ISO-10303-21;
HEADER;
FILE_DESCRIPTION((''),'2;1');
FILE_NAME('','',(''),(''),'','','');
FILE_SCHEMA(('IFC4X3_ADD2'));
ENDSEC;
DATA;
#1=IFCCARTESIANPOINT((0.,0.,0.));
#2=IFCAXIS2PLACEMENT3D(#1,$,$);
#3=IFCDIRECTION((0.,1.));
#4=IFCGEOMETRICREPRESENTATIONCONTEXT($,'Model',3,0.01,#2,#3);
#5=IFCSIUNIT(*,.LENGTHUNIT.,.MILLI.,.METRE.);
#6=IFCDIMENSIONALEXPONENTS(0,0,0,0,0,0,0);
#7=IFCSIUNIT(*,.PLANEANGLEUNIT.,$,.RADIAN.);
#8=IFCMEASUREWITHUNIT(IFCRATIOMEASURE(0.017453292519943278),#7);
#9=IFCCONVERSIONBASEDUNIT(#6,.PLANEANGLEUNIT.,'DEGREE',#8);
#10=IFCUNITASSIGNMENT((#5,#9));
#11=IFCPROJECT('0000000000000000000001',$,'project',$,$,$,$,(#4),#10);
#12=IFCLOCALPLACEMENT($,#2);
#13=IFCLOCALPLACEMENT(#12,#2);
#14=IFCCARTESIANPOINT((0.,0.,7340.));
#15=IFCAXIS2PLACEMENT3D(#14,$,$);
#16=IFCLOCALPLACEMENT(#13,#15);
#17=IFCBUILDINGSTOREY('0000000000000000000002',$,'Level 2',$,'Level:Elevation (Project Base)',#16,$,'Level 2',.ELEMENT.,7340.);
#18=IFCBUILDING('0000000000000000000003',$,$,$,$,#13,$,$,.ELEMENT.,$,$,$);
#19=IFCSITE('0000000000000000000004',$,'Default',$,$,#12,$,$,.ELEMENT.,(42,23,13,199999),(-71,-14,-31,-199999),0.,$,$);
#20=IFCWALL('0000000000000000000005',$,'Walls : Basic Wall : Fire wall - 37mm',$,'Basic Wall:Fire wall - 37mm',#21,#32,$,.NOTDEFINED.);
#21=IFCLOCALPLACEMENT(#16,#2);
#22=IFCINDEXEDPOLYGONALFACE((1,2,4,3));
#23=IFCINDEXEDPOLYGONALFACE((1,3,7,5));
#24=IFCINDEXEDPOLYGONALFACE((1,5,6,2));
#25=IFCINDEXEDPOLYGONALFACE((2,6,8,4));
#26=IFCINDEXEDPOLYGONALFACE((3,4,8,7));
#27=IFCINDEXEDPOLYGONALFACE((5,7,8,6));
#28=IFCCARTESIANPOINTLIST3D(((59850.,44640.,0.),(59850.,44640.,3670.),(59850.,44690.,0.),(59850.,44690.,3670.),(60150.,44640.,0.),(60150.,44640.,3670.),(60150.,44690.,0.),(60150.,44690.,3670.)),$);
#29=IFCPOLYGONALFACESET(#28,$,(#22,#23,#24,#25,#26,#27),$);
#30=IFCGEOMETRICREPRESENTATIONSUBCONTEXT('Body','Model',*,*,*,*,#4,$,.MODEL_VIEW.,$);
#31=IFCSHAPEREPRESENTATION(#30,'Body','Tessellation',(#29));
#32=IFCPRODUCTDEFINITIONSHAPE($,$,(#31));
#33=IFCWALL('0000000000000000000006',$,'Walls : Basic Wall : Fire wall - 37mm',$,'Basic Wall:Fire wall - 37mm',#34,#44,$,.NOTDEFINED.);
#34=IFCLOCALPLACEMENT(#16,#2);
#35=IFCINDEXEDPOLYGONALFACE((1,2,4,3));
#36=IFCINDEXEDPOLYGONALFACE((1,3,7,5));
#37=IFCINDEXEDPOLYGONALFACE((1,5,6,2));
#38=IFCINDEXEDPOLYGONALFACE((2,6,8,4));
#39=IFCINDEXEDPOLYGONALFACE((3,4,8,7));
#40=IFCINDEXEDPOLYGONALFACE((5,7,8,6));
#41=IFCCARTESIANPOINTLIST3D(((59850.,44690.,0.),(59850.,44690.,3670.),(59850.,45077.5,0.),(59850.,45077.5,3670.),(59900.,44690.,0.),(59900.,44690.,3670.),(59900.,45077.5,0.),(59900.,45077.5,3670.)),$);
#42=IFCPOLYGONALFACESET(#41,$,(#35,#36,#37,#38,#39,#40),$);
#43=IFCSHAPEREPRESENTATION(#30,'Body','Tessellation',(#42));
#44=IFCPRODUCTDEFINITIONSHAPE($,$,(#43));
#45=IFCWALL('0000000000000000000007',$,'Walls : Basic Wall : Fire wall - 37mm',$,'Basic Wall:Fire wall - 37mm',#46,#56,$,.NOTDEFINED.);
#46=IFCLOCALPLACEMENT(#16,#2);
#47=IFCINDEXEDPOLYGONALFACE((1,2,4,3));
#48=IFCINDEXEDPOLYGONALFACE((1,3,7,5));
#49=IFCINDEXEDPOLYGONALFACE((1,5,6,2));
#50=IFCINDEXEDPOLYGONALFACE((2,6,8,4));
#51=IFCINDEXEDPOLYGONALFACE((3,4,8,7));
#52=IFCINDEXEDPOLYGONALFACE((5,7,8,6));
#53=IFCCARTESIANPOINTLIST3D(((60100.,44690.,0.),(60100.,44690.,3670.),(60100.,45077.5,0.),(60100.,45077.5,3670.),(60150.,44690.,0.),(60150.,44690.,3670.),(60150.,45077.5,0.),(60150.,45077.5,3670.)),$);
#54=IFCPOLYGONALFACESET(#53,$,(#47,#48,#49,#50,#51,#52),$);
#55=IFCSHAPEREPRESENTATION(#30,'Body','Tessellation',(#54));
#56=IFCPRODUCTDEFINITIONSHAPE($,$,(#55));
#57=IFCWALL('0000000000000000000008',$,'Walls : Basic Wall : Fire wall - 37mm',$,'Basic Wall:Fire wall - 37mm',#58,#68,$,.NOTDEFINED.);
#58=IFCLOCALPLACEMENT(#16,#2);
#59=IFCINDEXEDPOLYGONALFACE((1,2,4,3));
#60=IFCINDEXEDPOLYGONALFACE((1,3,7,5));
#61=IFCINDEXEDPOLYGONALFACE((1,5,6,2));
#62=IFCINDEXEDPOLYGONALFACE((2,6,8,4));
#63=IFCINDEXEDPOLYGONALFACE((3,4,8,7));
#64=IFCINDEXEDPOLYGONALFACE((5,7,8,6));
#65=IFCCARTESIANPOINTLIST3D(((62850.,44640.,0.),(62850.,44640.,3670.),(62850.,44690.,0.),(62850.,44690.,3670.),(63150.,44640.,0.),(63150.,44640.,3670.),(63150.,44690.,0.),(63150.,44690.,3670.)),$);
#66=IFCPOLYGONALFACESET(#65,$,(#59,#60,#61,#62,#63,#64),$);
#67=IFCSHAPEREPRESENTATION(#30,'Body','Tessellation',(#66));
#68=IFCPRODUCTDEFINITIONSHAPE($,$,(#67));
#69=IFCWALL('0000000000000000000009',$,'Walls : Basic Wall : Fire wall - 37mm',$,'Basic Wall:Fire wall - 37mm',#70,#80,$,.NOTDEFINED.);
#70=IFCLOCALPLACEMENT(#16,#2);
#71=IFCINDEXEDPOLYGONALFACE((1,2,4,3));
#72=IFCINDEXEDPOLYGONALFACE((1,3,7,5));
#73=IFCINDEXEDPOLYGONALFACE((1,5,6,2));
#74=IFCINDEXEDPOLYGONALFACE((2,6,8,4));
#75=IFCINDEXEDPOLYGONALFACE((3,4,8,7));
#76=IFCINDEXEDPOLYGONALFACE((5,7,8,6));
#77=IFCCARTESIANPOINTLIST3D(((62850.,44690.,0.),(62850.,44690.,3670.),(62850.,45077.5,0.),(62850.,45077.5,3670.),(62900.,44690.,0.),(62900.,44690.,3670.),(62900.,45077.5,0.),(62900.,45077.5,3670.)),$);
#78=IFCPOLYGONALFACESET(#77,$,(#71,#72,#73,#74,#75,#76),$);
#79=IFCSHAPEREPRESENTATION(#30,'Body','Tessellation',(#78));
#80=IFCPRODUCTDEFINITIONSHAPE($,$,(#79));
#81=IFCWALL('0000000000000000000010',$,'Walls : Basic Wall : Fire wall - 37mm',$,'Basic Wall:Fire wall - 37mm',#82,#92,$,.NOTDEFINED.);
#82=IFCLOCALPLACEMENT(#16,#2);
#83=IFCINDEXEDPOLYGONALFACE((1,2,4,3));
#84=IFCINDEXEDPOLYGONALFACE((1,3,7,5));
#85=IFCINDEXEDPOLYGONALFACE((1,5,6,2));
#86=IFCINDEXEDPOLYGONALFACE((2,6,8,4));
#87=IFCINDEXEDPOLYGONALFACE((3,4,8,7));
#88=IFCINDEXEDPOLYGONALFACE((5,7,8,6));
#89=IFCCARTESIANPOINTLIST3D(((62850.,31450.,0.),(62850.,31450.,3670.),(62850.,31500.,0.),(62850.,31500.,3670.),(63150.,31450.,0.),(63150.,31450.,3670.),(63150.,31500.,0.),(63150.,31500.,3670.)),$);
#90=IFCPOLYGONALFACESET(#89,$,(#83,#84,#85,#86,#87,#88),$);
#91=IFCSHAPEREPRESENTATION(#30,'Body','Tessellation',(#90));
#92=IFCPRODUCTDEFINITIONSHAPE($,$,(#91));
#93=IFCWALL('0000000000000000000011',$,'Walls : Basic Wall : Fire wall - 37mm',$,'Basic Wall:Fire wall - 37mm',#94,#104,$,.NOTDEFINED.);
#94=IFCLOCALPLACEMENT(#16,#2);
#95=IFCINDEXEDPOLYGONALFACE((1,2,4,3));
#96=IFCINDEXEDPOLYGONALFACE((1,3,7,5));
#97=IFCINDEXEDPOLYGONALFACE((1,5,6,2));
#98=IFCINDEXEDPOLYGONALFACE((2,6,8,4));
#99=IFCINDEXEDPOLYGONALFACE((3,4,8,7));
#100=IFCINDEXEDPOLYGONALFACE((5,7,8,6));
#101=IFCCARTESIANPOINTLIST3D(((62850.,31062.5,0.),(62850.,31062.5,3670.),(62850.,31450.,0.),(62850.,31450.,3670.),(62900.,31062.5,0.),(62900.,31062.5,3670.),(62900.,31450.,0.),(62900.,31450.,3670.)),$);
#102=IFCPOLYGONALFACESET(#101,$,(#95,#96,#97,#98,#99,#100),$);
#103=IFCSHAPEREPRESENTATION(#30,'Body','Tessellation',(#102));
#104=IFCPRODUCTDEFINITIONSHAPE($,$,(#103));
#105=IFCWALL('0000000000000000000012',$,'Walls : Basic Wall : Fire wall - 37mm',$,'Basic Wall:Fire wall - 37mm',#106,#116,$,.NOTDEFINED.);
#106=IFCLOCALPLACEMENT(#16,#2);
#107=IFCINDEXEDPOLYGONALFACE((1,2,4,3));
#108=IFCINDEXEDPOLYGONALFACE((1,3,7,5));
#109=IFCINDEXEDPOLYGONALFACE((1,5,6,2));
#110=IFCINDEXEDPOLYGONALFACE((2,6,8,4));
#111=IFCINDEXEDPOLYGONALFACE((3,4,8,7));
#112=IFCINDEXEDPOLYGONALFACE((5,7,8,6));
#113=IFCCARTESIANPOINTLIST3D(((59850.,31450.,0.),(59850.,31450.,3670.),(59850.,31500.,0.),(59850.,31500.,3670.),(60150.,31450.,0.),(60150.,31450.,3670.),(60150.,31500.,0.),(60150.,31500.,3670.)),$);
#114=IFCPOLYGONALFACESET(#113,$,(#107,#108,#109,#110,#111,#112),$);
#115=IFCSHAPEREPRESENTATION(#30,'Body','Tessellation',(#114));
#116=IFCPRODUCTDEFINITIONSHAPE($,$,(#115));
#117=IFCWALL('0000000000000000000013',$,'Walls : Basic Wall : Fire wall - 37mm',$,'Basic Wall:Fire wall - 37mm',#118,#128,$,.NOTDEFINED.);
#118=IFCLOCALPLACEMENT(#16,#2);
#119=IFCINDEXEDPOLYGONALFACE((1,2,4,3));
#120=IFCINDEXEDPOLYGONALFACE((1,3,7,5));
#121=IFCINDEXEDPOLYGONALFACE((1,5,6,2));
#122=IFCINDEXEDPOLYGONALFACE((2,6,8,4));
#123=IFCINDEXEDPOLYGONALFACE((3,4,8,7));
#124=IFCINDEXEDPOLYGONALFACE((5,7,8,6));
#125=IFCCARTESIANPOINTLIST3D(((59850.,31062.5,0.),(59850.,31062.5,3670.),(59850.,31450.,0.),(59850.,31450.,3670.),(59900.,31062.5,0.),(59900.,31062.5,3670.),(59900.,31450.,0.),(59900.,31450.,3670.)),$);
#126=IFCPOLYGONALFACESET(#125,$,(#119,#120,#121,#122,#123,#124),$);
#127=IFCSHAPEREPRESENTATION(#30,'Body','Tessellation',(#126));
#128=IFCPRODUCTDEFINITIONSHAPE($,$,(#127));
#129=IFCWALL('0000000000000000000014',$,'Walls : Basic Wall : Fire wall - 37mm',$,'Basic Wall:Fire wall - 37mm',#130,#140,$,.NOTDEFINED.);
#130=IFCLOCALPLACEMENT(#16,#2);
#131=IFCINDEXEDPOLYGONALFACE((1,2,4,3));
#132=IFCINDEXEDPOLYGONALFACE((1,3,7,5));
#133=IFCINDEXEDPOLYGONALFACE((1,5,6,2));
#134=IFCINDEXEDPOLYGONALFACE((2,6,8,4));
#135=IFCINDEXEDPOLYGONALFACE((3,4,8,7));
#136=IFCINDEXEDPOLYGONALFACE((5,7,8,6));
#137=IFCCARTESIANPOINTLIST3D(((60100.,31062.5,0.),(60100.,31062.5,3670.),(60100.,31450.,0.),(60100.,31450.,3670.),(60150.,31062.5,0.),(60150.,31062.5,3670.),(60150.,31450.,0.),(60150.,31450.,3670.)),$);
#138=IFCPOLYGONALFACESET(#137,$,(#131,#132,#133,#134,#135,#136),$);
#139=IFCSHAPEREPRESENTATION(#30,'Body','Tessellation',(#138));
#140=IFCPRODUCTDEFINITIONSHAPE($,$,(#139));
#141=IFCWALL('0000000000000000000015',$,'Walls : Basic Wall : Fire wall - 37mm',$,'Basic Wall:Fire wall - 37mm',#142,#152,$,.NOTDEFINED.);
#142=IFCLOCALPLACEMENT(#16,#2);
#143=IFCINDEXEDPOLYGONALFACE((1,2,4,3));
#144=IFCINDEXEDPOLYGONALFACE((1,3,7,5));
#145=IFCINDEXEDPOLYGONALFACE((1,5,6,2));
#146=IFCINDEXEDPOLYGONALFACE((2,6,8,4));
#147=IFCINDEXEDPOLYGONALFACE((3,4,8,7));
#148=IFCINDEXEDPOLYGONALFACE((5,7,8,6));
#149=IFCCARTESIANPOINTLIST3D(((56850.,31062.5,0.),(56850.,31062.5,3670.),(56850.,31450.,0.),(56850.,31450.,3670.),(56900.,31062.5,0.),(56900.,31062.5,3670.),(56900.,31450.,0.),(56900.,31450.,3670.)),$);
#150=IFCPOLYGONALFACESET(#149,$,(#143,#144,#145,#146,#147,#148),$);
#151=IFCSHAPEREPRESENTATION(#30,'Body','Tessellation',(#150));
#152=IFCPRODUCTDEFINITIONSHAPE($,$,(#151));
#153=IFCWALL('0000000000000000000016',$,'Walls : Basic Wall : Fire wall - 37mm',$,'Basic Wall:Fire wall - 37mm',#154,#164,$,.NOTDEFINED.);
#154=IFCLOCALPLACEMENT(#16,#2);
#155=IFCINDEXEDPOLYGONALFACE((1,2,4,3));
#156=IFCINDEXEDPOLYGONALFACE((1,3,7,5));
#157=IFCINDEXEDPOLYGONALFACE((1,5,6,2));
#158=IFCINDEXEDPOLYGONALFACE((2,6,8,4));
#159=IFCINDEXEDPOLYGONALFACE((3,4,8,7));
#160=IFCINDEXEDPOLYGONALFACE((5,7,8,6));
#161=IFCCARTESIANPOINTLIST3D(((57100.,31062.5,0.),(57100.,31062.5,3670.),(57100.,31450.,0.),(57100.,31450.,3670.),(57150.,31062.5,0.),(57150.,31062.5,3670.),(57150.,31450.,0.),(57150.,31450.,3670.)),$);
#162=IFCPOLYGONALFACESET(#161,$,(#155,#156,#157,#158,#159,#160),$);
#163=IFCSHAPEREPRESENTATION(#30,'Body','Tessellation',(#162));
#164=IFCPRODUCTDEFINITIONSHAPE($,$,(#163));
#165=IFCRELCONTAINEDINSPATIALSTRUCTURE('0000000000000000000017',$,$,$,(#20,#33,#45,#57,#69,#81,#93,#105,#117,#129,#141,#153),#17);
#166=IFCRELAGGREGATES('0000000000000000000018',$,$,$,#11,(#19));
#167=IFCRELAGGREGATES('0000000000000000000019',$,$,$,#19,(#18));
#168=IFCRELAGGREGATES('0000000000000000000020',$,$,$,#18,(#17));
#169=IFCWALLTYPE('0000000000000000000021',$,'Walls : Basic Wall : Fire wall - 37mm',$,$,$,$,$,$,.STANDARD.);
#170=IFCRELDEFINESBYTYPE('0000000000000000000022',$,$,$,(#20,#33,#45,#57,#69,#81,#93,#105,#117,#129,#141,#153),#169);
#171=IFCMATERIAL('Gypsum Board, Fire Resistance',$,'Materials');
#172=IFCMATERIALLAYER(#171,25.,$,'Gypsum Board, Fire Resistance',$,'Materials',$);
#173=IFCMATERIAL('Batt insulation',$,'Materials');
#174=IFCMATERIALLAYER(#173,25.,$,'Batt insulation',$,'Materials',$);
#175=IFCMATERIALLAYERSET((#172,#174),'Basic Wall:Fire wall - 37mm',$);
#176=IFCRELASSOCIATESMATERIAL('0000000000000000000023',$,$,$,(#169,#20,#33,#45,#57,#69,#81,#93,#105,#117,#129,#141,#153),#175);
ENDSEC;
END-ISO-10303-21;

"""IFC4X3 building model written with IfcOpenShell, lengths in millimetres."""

from ifc_helpers import new_model, entity, si_unit, converted_unit, direction, frame, frame_2d, origin, place, context, subcontext, project, spatial, rectangle, extrude, material, layer, layer_set, type_object, element, save


model = new_model("IFC4X3")

# Units and contexts
model_context = context("Model", 3, precision=0.01, world=origin(), true_north=direction((0.0, 1.0)))
body_context = subcontext(model_context, "Body", "Model", "MODEL_VIEW")
ifc_project = project(units=[si_unit("LENGTHUNIT", "METRE", prefix="MILLI"), converted_unit("PLANEANGLEUNIT", "DEGREE", entity("IfcRatioMeasure", 0.017453292519943278), si_unit("PLANEANGLEUNIT", "RADIAN"), dimensions=[0, 0, 0, 0, 0, 0, 0])], contexts=[model_context])

# Site, building, storey
site_placement = place(None, origin())
site = spatial("IfcSite", under=ifc_project, at=site_placement, Name="Default", CompositionType="ELEMENT", RefLatitude=(42, 23, 13, 199999), RefLongitude=(-71, -14, -31, -199999), RefElevation=0.0)
building_placement = place(site_placement, origin())
building = spatial("IfcBuilding", under=site, at=building_placement, CompositionType="ELEMENT")
storey_placement = place(building_placement, frame((0.0, 0.0, 7340.0)))
storey = spatial("IfcBuildingStorey", under=building, at=storey_placement, Name="Level 2", ObjectType="Level:Elevation (Project Base)", LongName="Level 2", CompositionType="ELEMENT", Elevation=7340.0)

# Walls
ifc_material_1 = material(Name="Gypsum Board, Fire Resistance", Category="Materials")
ifc_layer_1 = layer(ifc_material_1, 25.0, Name="Gypsum Board, Fire Resistance", Category="Materials")
ifc_material_2 = material(Name="Batt insulation", Category="Materials")
ifc_layer_2 = layer(ifc_material_2, 25.0, Name="Batt insulation", Category="Materials")
ifc_layer_set = layer_set([ifc_layer_1, ifc_layer_2], Name="Basic Wall:Fire wall - 37mm")
wall_type = type_object("IfcWallType", Name="Walls : Basic Wall : Fire wall - 37mm", PredefinedType="STANDARD", material=ifc_layer_set)
wall_1_placement = place(storey_placement, frame((59850.0, 44665.0, 0.0)))
element("IfcWall", 1, at=wall_1_placement, inside=storey, type_object=wall_type, material=ifc_layer_set, Name="Walls : Basic Wall : Fire wall - 37mm", ObjectType="Basic Wall:Fire wall - 37mm", PredefinedType="NOTDEFINED", context=body_context, shape_type="SweptSolid", body=[
    extrude(rectangle(XDim=300.0, YDim=50.0, at=frame_2d((150.0, 0.0), x_axis=(-1.0, 0.0))), origin(), (0.0, 0.0, 1.0), 3670.0),
])
for number, where, z_axis, x_axis, name in (
    (2, (59875.0, 45077.5, 0.0), (0.0, 0.0, 1.0), (0.0, -1.0, 0.0), "Walls : Basic Wall : Fire wall - 37mm"),
    (3, (60125.0, 45077.5, 0.0), (0.0, 0.0, 1.0), (0.0, -1.0, 0.0), "Walls : Basic Wall : Fire wall - 37mm"),
):
    element("IfcWall", number, at=place(storey_placement, frame(where, z_axis=z_axis, x_axis=x_axis)), inside=storey, type_object=wall_type, material=ifc_layer_set, Name=name, ObjectType="Basic Wall:Fire wall - 37mm", PredefinedType="NOTDEFINED", context=body_context, shape_type="SweptSolid", body=[
        extrude(rectangle(XDim=387.5, YDim=50.0, at=frame_2d((193.7, 0.0), x_axis=(-1.0, 0.0))), origin(), (0.0, 0.0, 1.0), 3670.0),
    ])
wall_2_placement = place(storey_placement, frame((62850.0, 44665.0, 0.0)))
element("IfcWall", 4, at=wall_2_placement, inside=storey, type_object=wall_type, material=ifc_layer_set, Name="Walls : Basic Wall : Fire wall - 37mm", ObjectType="Basic Wall:Fire wall - 37mm", PredefinedType="NOTDEFINED", context=body_context, shape_type="SweptSolid", body=[
    extrude(rectangle(XDim=300.0, YDim=50.0, at=frame_2d((150.0, 0.0), x_axis=(-1.0, 0.0))), origin(), (0.0, 0.0, 1.0), 3670.0),
])
wall_3_placement = place(storey_placement, frame((62875.0, 45077.5, 0.0), z_axis=(0.0, 0.0, 1.0), x_axis=(0.0, -1.0, 0.0)))
element("IfcWall", 5, at=wall_3_placement, inside=storey, type_object=wall_type, material=ifc_layer_set, Name="Walls : Basic Wall : Fire wall - 37mm", ObjectType="Basic Wall:Fire wall - 37mm", PredefinedType="NOTDEFINED", context=body_context, shape_type="SweptSolid", body=[
    extrude(rectangle(XDim=387.5, YDim=50.0, at=frame_2d((193.7, 0.0), x_axis=(-1.0, 0.0))), origin(), (0.0, 0.0, 1.0), 3670.0),
])
wall_4_placement = place(storey_placement, frame((62850.0, 31475.0, 0.0)))
element("IfcWall", 6, at=wall_4_placement, inside=storey, type_object=wall_type, material=ifc_layer_set, Name="Walls : Basic Wall : Fire wall - 37mm", ObjectType="Basic Wall:Fire wall - 37mm", PredefinedType="NOTDEFINED", context=body_context, shape_type="SweptSolid", body=[
    extrude(rectangle(XDim=300.0, YDim=50.0, at=frame_2d((150.0, 0.0), x_axis=(-1.0, 0.0))), origin(), (0.0, 0.0, 1.0), 3670.0),
])
wall_5_placement = place(storey_placement, frame((62875.0, 31450.0, 0.0), z_axis=(0.0, 0.0, 1.0), x_axis=(0.0, -1.0, 0.0)))
element("IfcWall", 7, at=wall_5_placement, inside=storey, type_object=wall_type, material=ifc_layer_set, Name="Walls : Basic Wall : Fire wall - 37mm", ObjectType="Basic Wall:Fire wall - 37mm", PredefinedType="NOTDEFINED", context=body_context, shape_type="SweptSolid", body=[
    extrude(rectangle(XDim=387.5, YDim=50.0, at=frame_2d((193.7, 0.0), x_axis=(-1.0, 0.0))), origin(), (0.0, 0.0, 1.0), 3670.0),
])
wall_6_placement = place(storey_placement, frame((59850.0, 31475.0, 0.0)))
element("IfcWall", 8, at=wall_6_placement, inside=storey, type_object=wall_type, material=ifc_layer_set, Name="Walls : Basic Wall : Fire wall - 37mm", ObjectType="Basic Wall:Fire wall - 37mm", PredefinedType="NOTDEFINED", context=body_context, shape_type="SweptSolid", body=[
    extrude(rectangle(XDim=300.0, YDim=50.0, at=frame_2d((150.0, 0.0), x_axis=(-1.0, 0.0))), origin(), (0.0, 0.0, 1.0), 3670.0),
])
for number, where, z_axis, x_axis, name in (
    (9, (59875.0, 31450.0, 0.0), (0.0, 0.0, 1.0), (0.0, -1.0, 0.0), "Walls : Basic Wall : Fire wall - 37mm"),
    (10, (60125.0, 31450.0, 0.0), (0.0, 0.0, 1.0), (0.0, -1.0, 0.0), "Walls : Basic Wall : Fire wall - 37mm"),
):
    element("IfcWall", number, at=place(storey_placement, frame(where, z_axis=z_axis, x_axis=x_axis)), inside=storey, type_object=wall_type, material=ifc_layer_set, Name=name, ObjectType="Basic Wall:Fire wall - 37mm", PredefinedType="NOTDEFINED", context=body_context, shape_type="SweptSolid", body=[
        extrude(rectangle(XDim=387.5, YDim=50.0, at=frame_2d((193.7, 0.0), x_axis=(-1.0, 0.0))), origin(), (0.0, 0.0, 1.0), 3670.0),
    ])
wall_7_placement = place(storey_placement, frame((56875.0, 31450.0, 0.0), z_axis=(0.0, 0.0, 1.0), x_axis=(0.0, -1.0, 0.0)))
element("IfcWall", 11, at=wall_7_placement, inside=storey, type_object=wall_type, material=ifc_layer_set, Name="Walls : Basic Wall : Fire wall - 37mm", ObjectType="Basic Wall:Fire wall - 37mm", PredefinedType="NOTDEFINED", context=body_context, shape_type="SweptSolid", body=[
    extrude(rectangle(XDim=387.5, YDim=50.0, at=frame_2d((193.8, 0.0), x_axis=(-1.0, 0.0))), origin(), (0.0, 0.0, 1.0), 3670.0),
])
wall_8_placement = place(storey_placement, frame((57125.0, 31450.0, 0.0), z_axis=(0.0, 0.0, 1.0), x_axis=(0.0, -1.0, 0.0)))
element("IfcWall", 12, at=wall_8_placement, inside=storey, type_object=wall_type, material=ifc_layer_set, Name="Walls : Basic Wall : Fire wall - 37mm", ObjectType="Basic Wall:Fire wall - 37mm", PredefinedType="NOTDEFINED", context=body_context, shape_type="SweptSolid", body=[
    extrude(rectangle(XDim=387.5, YDim=50.0, at=frame_2d((193.8, 0.0), x_axis=(-1.0, 0.0))), origin(), (0.0, 0.0, 1.0), 3670.0),
])

save(model, "model.ifc")
